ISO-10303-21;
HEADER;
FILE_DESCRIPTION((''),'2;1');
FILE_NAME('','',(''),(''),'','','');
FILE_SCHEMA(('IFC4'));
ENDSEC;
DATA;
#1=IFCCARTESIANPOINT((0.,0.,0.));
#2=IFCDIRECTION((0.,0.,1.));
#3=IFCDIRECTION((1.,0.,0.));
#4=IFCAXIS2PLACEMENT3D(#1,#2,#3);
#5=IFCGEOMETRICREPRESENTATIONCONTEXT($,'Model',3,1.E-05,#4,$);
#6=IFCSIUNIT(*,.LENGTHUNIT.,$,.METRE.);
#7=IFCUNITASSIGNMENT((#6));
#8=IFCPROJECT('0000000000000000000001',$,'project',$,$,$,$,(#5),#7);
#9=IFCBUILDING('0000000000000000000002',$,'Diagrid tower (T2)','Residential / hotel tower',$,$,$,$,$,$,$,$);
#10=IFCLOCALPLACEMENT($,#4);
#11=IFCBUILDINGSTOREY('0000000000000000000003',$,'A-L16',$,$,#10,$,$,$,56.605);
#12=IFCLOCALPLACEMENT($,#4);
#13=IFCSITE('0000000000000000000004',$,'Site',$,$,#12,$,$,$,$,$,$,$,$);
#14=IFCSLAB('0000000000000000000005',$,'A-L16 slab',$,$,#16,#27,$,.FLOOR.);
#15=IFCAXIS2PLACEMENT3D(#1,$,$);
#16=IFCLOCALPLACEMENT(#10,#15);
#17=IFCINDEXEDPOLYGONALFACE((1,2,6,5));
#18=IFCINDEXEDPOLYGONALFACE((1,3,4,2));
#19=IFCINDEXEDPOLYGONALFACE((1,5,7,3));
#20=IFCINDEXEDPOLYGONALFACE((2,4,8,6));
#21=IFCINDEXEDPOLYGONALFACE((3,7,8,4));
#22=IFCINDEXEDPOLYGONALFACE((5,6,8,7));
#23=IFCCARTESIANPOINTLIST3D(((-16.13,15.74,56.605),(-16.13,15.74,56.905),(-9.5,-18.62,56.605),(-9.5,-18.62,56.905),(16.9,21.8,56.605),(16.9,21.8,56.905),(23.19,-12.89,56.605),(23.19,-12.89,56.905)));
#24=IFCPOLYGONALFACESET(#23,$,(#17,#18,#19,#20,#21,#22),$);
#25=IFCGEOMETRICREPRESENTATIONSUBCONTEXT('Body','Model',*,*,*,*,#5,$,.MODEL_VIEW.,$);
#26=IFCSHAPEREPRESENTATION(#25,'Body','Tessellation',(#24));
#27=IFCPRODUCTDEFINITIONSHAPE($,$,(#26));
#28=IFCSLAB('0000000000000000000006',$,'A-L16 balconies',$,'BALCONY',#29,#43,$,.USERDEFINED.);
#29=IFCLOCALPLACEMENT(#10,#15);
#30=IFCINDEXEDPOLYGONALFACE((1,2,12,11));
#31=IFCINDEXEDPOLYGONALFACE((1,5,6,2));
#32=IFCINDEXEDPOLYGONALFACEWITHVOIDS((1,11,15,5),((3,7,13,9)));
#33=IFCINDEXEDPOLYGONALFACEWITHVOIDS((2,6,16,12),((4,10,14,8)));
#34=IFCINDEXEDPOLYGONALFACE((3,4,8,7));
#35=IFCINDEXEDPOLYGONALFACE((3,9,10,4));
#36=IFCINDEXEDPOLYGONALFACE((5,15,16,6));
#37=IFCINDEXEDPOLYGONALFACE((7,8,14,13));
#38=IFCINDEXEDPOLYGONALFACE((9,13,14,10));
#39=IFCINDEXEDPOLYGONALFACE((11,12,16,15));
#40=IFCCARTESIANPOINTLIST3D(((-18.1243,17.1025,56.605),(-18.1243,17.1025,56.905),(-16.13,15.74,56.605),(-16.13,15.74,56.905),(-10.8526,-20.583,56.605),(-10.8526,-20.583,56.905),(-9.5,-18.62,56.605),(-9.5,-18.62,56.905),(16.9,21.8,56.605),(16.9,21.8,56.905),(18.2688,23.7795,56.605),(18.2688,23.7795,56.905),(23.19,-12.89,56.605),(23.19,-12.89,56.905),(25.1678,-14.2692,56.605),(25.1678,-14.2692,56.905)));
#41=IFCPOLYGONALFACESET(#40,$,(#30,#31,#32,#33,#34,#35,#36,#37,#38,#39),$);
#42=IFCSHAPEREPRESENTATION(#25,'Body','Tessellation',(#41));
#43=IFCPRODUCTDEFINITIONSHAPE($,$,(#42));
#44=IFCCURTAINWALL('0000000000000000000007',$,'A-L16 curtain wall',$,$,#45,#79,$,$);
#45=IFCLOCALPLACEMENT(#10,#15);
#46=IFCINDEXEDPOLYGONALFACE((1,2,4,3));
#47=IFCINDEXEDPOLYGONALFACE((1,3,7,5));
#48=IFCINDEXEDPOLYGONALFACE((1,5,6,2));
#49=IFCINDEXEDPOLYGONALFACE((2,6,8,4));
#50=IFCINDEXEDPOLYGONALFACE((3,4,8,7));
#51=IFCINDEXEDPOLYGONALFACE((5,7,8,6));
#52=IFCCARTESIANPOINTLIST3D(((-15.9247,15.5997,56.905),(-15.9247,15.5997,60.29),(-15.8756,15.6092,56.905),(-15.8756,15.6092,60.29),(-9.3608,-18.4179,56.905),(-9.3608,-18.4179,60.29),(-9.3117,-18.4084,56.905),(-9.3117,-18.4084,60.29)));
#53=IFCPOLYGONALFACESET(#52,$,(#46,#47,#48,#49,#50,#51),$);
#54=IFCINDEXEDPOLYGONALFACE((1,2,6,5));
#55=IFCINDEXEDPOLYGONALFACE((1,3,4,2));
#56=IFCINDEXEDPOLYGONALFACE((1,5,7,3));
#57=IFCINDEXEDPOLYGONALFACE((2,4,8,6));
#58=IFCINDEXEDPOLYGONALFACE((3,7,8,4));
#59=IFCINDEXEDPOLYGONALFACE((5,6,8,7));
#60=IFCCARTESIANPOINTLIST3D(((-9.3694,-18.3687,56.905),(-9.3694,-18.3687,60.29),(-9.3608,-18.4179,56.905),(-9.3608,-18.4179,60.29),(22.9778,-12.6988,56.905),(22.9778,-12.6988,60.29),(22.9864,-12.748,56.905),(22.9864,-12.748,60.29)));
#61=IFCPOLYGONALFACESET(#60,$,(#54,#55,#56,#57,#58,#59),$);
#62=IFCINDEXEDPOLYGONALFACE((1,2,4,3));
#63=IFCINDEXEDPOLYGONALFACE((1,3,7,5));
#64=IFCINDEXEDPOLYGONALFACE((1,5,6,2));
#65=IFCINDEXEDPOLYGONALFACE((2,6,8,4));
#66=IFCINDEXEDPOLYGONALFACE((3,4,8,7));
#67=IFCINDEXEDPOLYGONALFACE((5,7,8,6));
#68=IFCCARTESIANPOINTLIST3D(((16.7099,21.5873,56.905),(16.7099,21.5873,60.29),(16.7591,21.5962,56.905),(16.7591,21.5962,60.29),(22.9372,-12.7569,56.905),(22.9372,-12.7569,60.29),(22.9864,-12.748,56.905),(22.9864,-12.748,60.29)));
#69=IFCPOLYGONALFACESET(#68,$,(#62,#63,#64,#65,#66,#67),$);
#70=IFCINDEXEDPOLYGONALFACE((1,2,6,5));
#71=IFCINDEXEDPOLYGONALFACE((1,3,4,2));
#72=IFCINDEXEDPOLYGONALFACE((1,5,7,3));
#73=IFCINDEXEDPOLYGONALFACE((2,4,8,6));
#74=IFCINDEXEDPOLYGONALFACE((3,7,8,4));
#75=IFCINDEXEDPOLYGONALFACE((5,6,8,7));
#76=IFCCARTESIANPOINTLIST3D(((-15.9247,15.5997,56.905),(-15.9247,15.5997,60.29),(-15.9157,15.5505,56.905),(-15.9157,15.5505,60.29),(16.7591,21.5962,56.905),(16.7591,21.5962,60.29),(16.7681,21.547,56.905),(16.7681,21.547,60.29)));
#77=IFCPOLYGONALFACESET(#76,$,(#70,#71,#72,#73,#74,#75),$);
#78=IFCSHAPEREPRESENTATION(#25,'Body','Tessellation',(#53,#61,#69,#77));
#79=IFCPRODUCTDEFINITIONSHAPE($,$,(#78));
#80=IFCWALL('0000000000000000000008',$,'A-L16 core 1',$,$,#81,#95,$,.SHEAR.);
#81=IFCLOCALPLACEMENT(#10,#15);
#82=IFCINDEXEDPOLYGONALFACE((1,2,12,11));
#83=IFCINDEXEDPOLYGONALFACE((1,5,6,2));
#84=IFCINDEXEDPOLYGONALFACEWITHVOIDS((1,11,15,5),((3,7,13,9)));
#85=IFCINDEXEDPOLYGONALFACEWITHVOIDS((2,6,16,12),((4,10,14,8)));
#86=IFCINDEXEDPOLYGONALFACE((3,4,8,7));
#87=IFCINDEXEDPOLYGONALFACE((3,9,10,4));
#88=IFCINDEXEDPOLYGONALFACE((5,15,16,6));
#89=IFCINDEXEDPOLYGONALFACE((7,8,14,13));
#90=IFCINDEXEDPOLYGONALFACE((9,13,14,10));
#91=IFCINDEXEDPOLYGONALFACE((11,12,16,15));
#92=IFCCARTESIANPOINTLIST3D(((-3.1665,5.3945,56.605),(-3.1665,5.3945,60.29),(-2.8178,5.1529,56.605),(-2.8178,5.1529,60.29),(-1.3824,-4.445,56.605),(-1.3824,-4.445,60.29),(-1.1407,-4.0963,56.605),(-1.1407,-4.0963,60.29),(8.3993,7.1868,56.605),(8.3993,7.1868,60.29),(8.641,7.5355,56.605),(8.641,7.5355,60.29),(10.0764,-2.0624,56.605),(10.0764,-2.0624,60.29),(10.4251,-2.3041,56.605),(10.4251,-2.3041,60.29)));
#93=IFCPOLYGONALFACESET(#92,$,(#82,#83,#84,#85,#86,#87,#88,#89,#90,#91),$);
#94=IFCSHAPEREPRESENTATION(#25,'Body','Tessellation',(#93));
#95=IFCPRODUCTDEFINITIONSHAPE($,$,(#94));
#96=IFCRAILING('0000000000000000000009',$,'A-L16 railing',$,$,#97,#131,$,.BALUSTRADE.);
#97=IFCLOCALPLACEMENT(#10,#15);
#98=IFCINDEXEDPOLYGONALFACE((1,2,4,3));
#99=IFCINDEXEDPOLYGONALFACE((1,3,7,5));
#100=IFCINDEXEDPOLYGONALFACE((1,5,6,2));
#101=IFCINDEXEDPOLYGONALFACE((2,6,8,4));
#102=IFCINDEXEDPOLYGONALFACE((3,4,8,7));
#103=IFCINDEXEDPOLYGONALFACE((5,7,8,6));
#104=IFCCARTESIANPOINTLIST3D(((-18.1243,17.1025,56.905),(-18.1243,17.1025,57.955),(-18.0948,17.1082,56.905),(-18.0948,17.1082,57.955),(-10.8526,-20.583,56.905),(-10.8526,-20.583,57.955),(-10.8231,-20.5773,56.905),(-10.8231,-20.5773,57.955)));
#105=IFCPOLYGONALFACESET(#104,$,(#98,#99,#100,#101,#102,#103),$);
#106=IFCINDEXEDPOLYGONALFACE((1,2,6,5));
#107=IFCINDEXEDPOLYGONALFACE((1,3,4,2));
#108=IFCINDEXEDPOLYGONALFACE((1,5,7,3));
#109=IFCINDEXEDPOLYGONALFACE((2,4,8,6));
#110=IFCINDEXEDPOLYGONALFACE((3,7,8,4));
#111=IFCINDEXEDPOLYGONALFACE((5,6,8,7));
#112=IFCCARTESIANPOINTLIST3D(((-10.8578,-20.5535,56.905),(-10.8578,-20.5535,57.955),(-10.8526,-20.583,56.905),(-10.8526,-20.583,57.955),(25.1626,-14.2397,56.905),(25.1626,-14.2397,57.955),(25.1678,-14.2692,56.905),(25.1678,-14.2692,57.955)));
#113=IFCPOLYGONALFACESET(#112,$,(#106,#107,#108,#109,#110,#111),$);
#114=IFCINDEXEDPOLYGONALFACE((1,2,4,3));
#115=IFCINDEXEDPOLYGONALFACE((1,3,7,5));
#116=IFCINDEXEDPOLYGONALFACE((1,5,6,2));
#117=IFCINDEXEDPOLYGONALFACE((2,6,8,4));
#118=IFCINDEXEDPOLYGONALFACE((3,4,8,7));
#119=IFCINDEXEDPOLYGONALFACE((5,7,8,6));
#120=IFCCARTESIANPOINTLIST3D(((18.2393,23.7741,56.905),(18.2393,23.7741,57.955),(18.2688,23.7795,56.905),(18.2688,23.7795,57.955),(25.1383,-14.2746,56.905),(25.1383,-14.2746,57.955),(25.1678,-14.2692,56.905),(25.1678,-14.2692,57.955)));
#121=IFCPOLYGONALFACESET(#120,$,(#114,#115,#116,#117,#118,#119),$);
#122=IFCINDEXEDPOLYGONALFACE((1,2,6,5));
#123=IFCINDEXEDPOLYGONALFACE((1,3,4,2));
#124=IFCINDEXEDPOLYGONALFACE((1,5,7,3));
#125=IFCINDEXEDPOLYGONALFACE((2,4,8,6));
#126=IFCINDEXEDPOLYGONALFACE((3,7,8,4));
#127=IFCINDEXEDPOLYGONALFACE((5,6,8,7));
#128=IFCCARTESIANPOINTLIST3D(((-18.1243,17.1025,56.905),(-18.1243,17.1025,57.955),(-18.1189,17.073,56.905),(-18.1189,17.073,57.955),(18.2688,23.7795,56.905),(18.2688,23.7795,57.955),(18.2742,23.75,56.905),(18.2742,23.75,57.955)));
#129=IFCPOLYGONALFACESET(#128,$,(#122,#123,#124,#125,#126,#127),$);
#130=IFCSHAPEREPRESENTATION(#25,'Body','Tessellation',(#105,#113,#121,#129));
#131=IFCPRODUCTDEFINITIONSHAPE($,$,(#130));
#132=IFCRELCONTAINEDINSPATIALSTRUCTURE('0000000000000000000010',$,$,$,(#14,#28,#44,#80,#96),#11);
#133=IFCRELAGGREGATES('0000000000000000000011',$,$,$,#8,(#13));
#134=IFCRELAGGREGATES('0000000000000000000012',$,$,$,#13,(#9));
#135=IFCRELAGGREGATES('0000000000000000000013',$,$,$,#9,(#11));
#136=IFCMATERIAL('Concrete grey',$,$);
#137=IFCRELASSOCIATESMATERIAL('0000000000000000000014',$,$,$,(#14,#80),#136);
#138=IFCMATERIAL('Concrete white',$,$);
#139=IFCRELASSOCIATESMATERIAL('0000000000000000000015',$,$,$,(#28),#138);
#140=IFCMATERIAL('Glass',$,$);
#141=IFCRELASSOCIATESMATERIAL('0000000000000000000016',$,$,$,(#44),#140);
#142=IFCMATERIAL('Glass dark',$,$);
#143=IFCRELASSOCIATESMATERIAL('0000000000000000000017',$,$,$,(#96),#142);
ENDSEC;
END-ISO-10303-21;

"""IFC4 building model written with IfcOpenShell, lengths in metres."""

from ifc_helpers import new_model, si_unit, frame, origin_with_axes, place, context, subcontext, project, spatial, polyline, outline, extrude, material, element, save


model = new_model("IFC4")

# Units and contexts
model_context = context("Model", 3, precision=1e-05, world=origin_with_axes())
body_context = subcontext(model_context, "Body", "Model", "MODEL_VIEW")
ifc_project = project(units=[si_unit("LENGTHUNIT", "METRE")], contexts=[model_context])

# Site, building, storey
site_placement = place(None, origin_with_axes())
site = spatial("IfcSite", under=ifc_project, at=site_placement, Name="Site")
building = spatial("IfcBuilding", under=site, Name="Diagrid tower (T2)", Description="Residential / hotel tower")
storey_placement = place(None, origin_with_axes())
storey = spatial("IfcBuildingStorey", under=building, at=storey_placement, Name="A-L16", Elevation=56.605)

# Slabs
ifc_material_1 = material(Name="Concrete grey")
slab_1_placement = place(storey_placement, origin_with_axes())
element("IfcSlab", 1, at=slab_1_placement, inside=storey, material=ifc_material_1, Name="A-L16 slab", PredefinedType="FLOOR", context=body_context, shape_type="SweptSolid", body=[
    extrude(outline(polyline([(-16.13, 15.74), (-9.5, -18.62), (23.19, -12.89), (16.9, 21.8), (-16.13, 15.74)])), frame((0.0, 0.0, 56.605), z_axis=(0.0, 0.0, 1.0), x_axis=(1.0, 0.0, 0.0)), (0.0, 0.0, 1.0), 0.3),
])
ifc_material_2 = material(Name="Concrete white")
slab_2_placement = place(storey_placement, origin_with_axes())
element("IfcSlab", 2, at=slab_2_placement, inside=storey, material=ifc_material_2, Name="A-L16 balconies", ObjectType="BALCONY", PredefinedType="USERDEFINED", context=body_context, shape_type="SweptSolid", body=[
    extrude(outline(polyline([(-18.1243, 17.1025), (-10.8526, -20.583), (25.1678, -14.2692), (18.2688, 23.7795), (-18.1243, 17.1025)]), holes=[polyline([(-16.13, 15.74), (-9.5, -18.62), (23.19, -12.89), (16.9, 21.8), (-16.13, 15.74)])]), frame((0.0, 0.0, 56.605), z_axis=(0.0, 0.0, 1.0), x_axis=(1.0, 0.0, 0.0)), (0.0, 0.0, 1.0), 0.3),
])

# Curtain wall
ifc_material_3 = material(Name="Glass")
curtain_wall_placement = place(storey_placement, origin_with_axes())
element("IfcCurtainWall", 3, at=curtain_wall_placement, inside=storey, material=ifc_material_3, Name="A-L16 curtain wall", context=body_context, shape_type="SweptSolid", body=[
    extrude(outline(polyline([(-15.9247, 15.5997), (-9.3608, -18.4179), (-9.3117, -18.4084), (-15.8756, 15.6092), (-15.9247, 15.5997)])), frame((0.0, 0.0, 56.905), z_axis=(0.0, 0.0, 1.0), x_axis=(1.0, 0.0, 0.0)), (0.0, 0.0, 1.0), 3.385),
    extrude(outline(polyline([(-9.3608, -18.4179), (22.9864, -12.748), (22.9778, -12.6988), (-9.3694, -18.3687), (-9.3608, -18.4179)])), frame((0.0, 0.0, 56.905), z_axis=(0.0, 0.0, 1.0), x_axis=(1.0, 0.0, 0.0)), (0.0, 0.0, 1.0), 3.385),
    extrude(outline(polyline([(22.9864, -12.748), (16.7591, 21.5962), (16.7099, 21.5873), (22.9372, -12.7569), (22.9864, -12.748)])), frame((0.0, 0.0, 56.905), z_axis=(0.0, 0.0, 1.0), x_axis=(1.0, 0.0, 0.0)), (0.0, 0.0, 1.0), 3.385),
    extrude(outline(polyline([(16.7591, 21.5962), (-15.9247, 15.5997), (-15.9157, 15.5505), (16.7681, 21.547), (16.7591, 21.5962)])), frame((0.0, 0.0, 56.905), z_axis=(0.0, 0.0, 1.0), x_axis=(1.0, 0.0, 0.0)), (0.0, 0.0, 1.0), 3.385),
])

# Wall
wall_placement = place(storey_placement, origin_with_axes())
element("IfcWall", 4, at=wall_placement, inside=storey, material=ifc_material_1, Name="A-L16 core 1", PredefinedType="SHEAR", context=body_context, shape_type="SweptSolid", body=[
    extrude(outline(polyline([(10.4251, -2.3041), (8.641, 7.5355), (-3.1665, 5.3945), (-1.3824, -4.445), (10.4251, -2.3041)]), holes=[polyline([(10.0764, -2.0624), (8.3993, 7.1868), (-2.8178, 5.1529), (-1.1407, -4.0963), (10.0764, -2.0624)])]), frame((0.0, 0.0, 56.605), z_axis=(0.0, 0.0, 1.0), x_axis=(1.0, 0.0, 0.0)), (0.0, 0.0, 1.0), 3.685),
])

# Railing
ifc_material_4 = material(Name="Glass dark")
railing_placement = place(storey_placement, origin_with_axes())
element("IfcRailing", 5, at=railing_placement, inside=storey, material=ifc_material_4, Name="A-L16 railing", PredefinedType="BALUSTRADE", context=body_context, shape_type="SweptSolid", body=[
    extrude(outline(polyline([(-18.1243, 17.1025), (-10.8526, -20.583), (-10.8231, -20.5773), (-18.0948, 17.1082), (-18.1243, 17.1025)])), frame((0.0, 0.0, 56.905), z_axis=(0.0, 0.0, 1.0), x_axis=(1.0, 0.0, 0.0)), (0.0, 0.0, 1.0), 1.05),
    extrude(outline(polyline([(-10.8526, -20.583), (25.1678, -14.2692), (25.1626, -14.2397), (-10.8578, -20.5535), (-10.8526, -20.583)])), frame((0.0, 0.0, 56.905), z_axis=(0.0, 0.0, 1.0), x_axis=(1.0, 0.0, 0.0)), (0.0, 0.0, 1.0), 1.05),
    extrude(outline(polyline([(25.1678, -14.2692), (18.2688, 23.7795), (18.2393, 23.7741), (25.1383, -14.2746), (25.1678, -14.2692)])), frame((0.0, 0.0, 56.905), z_axis=(0.0, 0.0, 1.0), x_axis=(1.0, 0.0, 0.0)), (0.0, 0.0, 1.0), 1.05),
    extrude(outline(polyline([(18.2688, 23.7795), (-18.1243, 17.1025), (-18.1189, 17.073), (18.2742, 23.75), (18.2688, 23.7795)])), frame((0.0, 0.0, 56.905), z_axis=(0.0, 0.0, 1.0), x_axis=(1.0, 0.0, 0.0)), (0.0, 0.0, 1.0), 1.05),
])

save(model, "model.ifc")
